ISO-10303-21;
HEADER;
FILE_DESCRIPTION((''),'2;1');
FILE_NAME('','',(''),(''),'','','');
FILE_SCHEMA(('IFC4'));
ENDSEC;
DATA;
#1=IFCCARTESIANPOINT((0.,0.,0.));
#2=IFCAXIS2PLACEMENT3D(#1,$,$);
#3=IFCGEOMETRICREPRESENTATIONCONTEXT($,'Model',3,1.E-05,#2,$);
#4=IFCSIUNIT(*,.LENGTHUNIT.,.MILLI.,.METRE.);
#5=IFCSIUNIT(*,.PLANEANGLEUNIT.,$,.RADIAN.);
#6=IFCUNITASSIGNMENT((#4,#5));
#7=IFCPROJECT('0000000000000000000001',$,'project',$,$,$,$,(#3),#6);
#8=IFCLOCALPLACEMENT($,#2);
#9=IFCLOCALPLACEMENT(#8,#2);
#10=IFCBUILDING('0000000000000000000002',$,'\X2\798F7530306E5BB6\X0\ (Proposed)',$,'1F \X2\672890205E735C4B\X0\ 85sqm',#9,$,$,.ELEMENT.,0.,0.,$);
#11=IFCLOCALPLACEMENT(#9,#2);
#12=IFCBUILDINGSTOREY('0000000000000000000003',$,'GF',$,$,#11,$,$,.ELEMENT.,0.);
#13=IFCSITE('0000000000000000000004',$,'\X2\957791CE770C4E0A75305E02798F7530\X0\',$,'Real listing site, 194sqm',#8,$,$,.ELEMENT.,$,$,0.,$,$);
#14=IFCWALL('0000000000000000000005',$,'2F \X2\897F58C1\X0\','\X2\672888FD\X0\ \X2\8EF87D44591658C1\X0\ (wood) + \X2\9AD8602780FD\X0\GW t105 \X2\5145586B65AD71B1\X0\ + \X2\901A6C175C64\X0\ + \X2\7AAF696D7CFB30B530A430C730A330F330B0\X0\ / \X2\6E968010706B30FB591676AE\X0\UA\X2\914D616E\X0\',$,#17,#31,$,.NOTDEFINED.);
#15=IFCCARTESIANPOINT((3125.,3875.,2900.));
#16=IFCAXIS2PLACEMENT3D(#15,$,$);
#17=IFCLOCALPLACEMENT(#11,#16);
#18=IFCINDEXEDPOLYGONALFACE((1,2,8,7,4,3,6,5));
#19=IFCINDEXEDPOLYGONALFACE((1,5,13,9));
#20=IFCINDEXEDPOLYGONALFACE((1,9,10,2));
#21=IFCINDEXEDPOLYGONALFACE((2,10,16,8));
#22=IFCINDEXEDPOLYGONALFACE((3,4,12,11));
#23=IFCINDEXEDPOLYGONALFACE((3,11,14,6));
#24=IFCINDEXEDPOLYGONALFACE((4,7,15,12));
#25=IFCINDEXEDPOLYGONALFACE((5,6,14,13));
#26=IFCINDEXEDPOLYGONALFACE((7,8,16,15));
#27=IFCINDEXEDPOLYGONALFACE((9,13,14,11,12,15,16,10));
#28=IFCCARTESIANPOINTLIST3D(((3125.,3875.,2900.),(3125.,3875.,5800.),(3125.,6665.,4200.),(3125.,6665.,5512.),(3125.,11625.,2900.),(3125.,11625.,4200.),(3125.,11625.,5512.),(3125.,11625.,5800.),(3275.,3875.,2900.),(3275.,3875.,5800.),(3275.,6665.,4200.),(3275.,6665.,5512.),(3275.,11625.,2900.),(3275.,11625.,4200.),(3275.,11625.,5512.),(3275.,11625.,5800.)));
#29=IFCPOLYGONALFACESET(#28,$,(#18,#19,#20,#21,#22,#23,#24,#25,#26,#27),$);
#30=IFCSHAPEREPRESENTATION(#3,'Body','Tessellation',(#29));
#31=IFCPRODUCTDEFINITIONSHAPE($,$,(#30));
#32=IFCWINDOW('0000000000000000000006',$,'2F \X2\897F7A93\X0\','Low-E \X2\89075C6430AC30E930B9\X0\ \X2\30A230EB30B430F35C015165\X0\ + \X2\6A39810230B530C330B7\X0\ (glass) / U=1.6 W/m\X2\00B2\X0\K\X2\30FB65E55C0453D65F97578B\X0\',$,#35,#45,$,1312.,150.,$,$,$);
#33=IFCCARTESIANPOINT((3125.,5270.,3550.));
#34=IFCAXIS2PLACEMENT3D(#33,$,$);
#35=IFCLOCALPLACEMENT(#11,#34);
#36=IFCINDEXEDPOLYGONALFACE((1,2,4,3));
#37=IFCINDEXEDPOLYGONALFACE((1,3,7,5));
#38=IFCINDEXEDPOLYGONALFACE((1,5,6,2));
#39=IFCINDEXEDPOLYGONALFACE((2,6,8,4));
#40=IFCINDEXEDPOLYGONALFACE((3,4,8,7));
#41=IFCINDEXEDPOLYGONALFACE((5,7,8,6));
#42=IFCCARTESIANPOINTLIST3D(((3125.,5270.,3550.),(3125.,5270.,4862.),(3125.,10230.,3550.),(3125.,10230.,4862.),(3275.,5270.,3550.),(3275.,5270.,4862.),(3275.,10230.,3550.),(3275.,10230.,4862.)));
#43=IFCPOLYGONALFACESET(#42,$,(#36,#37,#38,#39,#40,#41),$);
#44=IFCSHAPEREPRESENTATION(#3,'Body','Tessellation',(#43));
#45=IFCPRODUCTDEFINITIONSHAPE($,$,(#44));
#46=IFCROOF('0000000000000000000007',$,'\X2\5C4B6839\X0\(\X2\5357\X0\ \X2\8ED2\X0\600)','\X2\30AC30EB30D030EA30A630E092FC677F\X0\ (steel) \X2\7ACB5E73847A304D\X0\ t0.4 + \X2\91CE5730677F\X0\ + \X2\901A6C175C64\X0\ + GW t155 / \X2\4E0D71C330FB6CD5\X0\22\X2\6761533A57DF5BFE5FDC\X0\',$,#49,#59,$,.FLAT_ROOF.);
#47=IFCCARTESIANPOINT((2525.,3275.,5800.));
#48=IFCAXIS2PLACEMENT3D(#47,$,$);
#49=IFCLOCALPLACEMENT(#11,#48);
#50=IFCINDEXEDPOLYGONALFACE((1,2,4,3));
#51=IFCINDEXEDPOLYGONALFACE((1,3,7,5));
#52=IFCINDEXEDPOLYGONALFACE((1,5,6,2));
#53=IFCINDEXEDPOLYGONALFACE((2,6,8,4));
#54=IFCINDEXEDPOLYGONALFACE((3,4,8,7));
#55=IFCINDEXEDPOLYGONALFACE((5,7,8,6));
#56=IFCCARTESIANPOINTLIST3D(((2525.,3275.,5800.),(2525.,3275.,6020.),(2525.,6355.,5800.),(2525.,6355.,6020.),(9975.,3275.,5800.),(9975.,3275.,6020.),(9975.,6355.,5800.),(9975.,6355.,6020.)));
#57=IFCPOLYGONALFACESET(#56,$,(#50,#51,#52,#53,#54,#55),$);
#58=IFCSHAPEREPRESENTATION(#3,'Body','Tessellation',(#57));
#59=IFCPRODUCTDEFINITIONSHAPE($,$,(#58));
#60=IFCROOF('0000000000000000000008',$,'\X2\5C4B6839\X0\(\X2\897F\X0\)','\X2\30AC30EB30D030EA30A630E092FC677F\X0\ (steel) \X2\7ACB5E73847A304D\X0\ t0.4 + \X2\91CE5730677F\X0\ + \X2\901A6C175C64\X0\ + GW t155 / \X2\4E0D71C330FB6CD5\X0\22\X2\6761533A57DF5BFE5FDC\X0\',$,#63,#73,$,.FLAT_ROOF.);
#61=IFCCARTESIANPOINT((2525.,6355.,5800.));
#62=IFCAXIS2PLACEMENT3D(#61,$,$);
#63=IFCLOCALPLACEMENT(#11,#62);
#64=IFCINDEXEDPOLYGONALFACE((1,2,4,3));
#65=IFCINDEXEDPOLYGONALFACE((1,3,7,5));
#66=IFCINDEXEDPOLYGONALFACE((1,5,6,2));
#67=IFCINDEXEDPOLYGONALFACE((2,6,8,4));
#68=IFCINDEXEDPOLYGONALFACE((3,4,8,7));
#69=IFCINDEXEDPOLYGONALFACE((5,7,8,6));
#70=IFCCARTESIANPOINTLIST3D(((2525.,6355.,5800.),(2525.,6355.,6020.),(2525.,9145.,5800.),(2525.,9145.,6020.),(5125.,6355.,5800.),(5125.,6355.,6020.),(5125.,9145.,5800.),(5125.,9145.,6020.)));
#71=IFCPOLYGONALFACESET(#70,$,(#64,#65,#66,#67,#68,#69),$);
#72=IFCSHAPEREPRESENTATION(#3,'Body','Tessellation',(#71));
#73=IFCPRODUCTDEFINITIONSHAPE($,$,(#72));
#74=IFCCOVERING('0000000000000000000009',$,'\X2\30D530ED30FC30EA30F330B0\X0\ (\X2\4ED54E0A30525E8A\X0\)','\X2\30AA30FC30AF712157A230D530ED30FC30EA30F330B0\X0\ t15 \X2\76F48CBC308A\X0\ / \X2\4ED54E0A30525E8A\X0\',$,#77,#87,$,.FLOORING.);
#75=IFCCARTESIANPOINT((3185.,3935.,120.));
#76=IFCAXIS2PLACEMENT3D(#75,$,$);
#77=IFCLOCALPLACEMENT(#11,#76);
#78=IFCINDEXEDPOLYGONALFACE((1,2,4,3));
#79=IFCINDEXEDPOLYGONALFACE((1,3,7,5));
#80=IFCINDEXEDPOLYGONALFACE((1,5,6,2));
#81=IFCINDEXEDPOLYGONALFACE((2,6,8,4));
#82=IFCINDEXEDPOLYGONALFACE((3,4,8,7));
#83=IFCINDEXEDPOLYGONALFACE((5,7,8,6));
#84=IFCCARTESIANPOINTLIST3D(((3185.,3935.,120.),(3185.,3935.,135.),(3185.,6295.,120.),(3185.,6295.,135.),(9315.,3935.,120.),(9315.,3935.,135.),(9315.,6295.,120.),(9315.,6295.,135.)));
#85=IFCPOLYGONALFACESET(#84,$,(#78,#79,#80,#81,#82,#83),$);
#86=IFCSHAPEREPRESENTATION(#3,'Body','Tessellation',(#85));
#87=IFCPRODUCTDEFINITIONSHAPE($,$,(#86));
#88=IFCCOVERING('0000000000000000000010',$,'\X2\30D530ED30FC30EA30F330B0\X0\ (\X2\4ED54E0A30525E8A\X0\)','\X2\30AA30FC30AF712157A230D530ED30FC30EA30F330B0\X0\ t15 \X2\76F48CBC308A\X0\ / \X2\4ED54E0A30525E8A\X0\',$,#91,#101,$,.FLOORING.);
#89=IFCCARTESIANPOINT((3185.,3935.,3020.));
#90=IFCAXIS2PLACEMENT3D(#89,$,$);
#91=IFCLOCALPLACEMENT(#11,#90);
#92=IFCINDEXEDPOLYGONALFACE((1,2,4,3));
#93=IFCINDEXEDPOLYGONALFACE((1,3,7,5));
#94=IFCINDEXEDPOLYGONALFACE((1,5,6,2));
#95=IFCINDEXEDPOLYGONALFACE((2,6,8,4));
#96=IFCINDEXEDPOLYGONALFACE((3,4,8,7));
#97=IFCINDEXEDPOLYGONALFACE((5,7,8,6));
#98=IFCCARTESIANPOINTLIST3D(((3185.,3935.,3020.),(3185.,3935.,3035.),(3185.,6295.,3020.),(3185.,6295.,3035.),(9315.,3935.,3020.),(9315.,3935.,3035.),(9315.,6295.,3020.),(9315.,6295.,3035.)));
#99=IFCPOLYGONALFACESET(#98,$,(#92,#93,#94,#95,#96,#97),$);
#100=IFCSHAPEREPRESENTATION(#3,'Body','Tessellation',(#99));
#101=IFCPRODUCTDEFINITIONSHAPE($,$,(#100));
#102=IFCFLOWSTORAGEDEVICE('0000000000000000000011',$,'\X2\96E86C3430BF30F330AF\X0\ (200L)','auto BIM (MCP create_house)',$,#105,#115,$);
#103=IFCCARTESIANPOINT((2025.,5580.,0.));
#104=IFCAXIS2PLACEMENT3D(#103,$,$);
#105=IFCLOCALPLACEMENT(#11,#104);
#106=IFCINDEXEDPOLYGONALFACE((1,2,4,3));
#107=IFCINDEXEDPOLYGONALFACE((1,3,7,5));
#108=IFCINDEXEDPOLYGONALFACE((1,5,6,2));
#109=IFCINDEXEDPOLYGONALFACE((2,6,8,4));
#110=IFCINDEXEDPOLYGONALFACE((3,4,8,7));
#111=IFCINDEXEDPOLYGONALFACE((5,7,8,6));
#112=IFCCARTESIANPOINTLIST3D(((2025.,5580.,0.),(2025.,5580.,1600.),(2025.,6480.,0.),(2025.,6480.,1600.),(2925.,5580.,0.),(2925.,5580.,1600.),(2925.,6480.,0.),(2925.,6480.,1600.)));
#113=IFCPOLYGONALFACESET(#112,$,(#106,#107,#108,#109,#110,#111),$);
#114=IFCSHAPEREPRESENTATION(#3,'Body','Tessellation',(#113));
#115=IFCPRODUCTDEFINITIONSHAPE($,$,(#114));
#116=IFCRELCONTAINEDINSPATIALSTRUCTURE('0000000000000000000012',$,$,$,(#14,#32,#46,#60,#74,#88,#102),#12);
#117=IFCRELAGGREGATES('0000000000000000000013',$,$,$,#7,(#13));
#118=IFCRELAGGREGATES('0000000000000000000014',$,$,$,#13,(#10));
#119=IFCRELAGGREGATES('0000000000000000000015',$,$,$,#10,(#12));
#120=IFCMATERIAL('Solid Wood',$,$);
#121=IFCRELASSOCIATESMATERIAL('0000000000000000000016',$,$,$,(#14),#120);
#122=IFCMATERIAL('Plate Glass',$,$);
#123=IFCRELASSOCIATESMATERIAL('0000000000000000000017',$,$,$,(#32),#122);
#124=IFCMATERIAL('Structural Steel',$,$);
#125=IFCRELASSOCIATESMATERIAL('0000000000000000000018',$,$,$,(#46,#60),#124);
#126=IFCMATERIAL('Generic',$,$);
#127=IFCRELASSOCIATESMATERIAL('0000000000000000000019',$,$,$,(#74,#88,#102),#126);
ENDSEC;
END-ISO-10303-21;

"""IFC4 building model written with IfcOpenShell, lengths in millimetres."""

from ifc_helpers import new_model, si_unit, frame, frame_2d, origin, place, context, project, spatial, rectangle, extrude, material, element, fill, save


model = new_model("IFC4")

# Units and contexts
model_context = context("Model", 3, precision=1e-05, world=origin())
ifc_project = project(units=[si_unit("LENGTHUNIT", "METRE", prefix="MILLI"), si_unit("PLANEANGLEUNIT", "RADIAN")], contexts=[model_context])

# Site, building, storey
site_placement = place(None, origin())
site = spatial("IfcSite", under=ifc_project, at=site_placement, Name="長野県上田市福田", ObjectType="Real listing site, 194sqm", CompositionType="ELEMENT", RefElevation=0.0)
building_placement = place(site_placement, origin())
building = spatial("IfcBuilding", under=site, at=building_placement, Name="福田の家 (Proposed)", ObjectType="1F 木造平屋 85sqm", CompositionType="ELEMENT", ElevationOfRefHeight=0.0, ElevationOfTerrain=0.0)
storey_placement = place(building_placement, origin())
storey = spatial("IfcBuildingStorey", under=building, at=storey_placement, Name="GF", CompositionType="ELEMENT", Elevation=0.0)

# Shared definitions
ifc_material_1 = material(Name="Solid Wood")
ifc_material_2 = material(Name="Generic")

# Shared definitions
ifc_material_3 = material(Name="Plate Glass")

# Wall, opening, window
wall_1_placement = place(storey_placement, frame((3125.0, 3875.0, 2900.0)))
wall_1 = element("IfcWall", 1, at=wall_1_placement, inside=storey, material=ifc_material_1, Name="2F 西壁", Description="木製 軸組外壁 (wood) + 高性能GW t105 充填断熱 + 通気層 + 窯業系サイディング / 準耐火・外皮UA配慮", PredefinedType="NOTDEFINED", context=model_context, shape_type="SweptSolid", body=[
    extrude(rectangle(XDim=150.0, YDim=7750.0, at=frame_2d((75.0, 3875.0))), frame((3125.0, 3875.0, 2900.0)), (0.0, 0.0, 1.0), 2900.0),
])
opening_1_placement = place(storey_placement, frame((3125.0, 5270.0, 3550.0)))
opening_1 = element("IfcOpeningElement", 2, at=opening_1_placement, cuts=wall_1, PredefinedType="NOTDEFINED", context=model_context, shape_type="SweptSolid", body=[
    extrude(rectangle(XDim=150.0, YDim=4960.0, at=frame_2d((75.0, 2480.0))), frame((3125.0, 5270.0, 3550.0)), (0.0, 0.0, 1.0), 1312.0),
])
window_1_placement = place(storey_placement, frame((3125.0, 5270.0, 3550.0)))
window_1 = element("IfcWindow", 3, at=window_1_placement, inside=storey, material=ifc_material_3, Name="2F 西窓", Description="Low-E 複層ガラス アルゴン封入 + 樹脂サッシ (glass) / U=1.6 W/m²K・日射取得型", OverallHeight=1312.0, OverallWidth=150.0, context=model_context, shape_type="SweptSolid", body=[
    extrude(rectangle(XDim=150.0, YDim=4960.0, at=frame_2d((75.0, 2480.0))), frame((3125.0, 5270.0, 3550.0)), (0.0, 0.0, 1.0), 1312.0),
])
fill(opening_1, window_1)

# Roofs
ifc_material_4 = material(Name="Structural Steel")
roof_1_placement = place(storey_placement, frame((2525.0, 3275.0, 5800.0)))
element("IfcRoof", 4, at=roof_1_placement, inside=storey, material=ifc_material_4, Name="屋根(南 軒600)", Description="ガルバリウム鋼板 (steel) 立平葺き t0.4 + 野地板 + 通気層 + GW t155 / 不燃・法22条区域対応", PredefinedType="FLAT_ROOF", context=model_context, shape_type="SweptSolid", body=[
    extrude(rectangle(XDim=7450.0, YDim=3080.0, at=frame_2d((3725.0, 1540.0))), frame((2525.0, 3275.0, 5800.0)), (0.0, 0.0, 1.0), 220.0),
])
roof_2_placement = place(storey_placement, frame((2525.0, 6355.0, 5800.0)))
element("IfcRoof", 5, at=roof_2_placement, inside=storey, material=ifc_material_4, Name="屋根(西)", Description="ガルバリウム鋼板 (steel) 立平葺き t0.4 + 野地板 + 通気層 + GW t155 / 不燃・法22条区域対応", PredefinedType="FLAT_ROOF", context=model_context, shape_type="SweptSolid", body=[
    extrude(rectangle(XDim=2600.0, YDim=2790.0, at=frame_2d((1300.0, 1395.0))), frame((2525.0, 6355.0, 5800.0)), (0.0, 0.0, 1.0), 220.0),
])

# Coverings
covering_1_placement = place(storey_placement, frame((3185.0, 3935.0, 120.0)))
element("IfcCovering", 6, at=covering_1_placement, inside=storey, material=ifc_material_2, Name="フローリング (仕上げ床)", Description="オーク無垢フローリング t15 直貼り / 仕上げ床", PredefinedType="FLOORING", context=model_context, shape_type="SweptSolid", body=[
    extrude(rectangle(XDim=6130.0, YDim=2360.0, at=frame_2d((3065.0, 1180.0))), frame((3185.0, 3935.0, 120.0)), (0.0, 0.0, 1.0), 15.0),
])
covering_2_placement = place(storey_placement, frame((3185.0, 3935.0, 3020.0)))
element("IfcCovering", 7, at=covering_2_placement, inside=storey, material=ifc_material_2, Name="フローリング (仕上げ床)", Description="オーク無垢フローリング t15 直貼り / 仕上げ床", PredefinedType="FLOORING", context=model_context, shape_type="SweptSolid", body=[
    extrude(rectangle(XDim=6130.0, YDim=2360.0, at=frame_2d((3065.0, 1180.0))), frame((3185.0, 3935.0, 3020.0)), (0.0, 0.0, 1.0), 15.0),
])

# Flow storage device
flow_storage_device_placement = place(storey_placement, frame((2025.0, 5580.0, 0.0)))
element("IfcFlowStorageDevice", 8, at=flow_storage_device_placement, inside=storey, material=ifc_material_2, Name="雨水タンク (200L)", Description="auto BIM (MCP create_house)", context=model_context, shape_type="SweptSolid", body=[
    extrude(rectangle(XDim=900.0, YDim=900.0, at=frame_2d((450.0, 450.0))), frame((2025.0, 5580.0, 0.0)), (0.0, 0.0, 1.0), 1600.0),
])

save(model, "model.ifc")
